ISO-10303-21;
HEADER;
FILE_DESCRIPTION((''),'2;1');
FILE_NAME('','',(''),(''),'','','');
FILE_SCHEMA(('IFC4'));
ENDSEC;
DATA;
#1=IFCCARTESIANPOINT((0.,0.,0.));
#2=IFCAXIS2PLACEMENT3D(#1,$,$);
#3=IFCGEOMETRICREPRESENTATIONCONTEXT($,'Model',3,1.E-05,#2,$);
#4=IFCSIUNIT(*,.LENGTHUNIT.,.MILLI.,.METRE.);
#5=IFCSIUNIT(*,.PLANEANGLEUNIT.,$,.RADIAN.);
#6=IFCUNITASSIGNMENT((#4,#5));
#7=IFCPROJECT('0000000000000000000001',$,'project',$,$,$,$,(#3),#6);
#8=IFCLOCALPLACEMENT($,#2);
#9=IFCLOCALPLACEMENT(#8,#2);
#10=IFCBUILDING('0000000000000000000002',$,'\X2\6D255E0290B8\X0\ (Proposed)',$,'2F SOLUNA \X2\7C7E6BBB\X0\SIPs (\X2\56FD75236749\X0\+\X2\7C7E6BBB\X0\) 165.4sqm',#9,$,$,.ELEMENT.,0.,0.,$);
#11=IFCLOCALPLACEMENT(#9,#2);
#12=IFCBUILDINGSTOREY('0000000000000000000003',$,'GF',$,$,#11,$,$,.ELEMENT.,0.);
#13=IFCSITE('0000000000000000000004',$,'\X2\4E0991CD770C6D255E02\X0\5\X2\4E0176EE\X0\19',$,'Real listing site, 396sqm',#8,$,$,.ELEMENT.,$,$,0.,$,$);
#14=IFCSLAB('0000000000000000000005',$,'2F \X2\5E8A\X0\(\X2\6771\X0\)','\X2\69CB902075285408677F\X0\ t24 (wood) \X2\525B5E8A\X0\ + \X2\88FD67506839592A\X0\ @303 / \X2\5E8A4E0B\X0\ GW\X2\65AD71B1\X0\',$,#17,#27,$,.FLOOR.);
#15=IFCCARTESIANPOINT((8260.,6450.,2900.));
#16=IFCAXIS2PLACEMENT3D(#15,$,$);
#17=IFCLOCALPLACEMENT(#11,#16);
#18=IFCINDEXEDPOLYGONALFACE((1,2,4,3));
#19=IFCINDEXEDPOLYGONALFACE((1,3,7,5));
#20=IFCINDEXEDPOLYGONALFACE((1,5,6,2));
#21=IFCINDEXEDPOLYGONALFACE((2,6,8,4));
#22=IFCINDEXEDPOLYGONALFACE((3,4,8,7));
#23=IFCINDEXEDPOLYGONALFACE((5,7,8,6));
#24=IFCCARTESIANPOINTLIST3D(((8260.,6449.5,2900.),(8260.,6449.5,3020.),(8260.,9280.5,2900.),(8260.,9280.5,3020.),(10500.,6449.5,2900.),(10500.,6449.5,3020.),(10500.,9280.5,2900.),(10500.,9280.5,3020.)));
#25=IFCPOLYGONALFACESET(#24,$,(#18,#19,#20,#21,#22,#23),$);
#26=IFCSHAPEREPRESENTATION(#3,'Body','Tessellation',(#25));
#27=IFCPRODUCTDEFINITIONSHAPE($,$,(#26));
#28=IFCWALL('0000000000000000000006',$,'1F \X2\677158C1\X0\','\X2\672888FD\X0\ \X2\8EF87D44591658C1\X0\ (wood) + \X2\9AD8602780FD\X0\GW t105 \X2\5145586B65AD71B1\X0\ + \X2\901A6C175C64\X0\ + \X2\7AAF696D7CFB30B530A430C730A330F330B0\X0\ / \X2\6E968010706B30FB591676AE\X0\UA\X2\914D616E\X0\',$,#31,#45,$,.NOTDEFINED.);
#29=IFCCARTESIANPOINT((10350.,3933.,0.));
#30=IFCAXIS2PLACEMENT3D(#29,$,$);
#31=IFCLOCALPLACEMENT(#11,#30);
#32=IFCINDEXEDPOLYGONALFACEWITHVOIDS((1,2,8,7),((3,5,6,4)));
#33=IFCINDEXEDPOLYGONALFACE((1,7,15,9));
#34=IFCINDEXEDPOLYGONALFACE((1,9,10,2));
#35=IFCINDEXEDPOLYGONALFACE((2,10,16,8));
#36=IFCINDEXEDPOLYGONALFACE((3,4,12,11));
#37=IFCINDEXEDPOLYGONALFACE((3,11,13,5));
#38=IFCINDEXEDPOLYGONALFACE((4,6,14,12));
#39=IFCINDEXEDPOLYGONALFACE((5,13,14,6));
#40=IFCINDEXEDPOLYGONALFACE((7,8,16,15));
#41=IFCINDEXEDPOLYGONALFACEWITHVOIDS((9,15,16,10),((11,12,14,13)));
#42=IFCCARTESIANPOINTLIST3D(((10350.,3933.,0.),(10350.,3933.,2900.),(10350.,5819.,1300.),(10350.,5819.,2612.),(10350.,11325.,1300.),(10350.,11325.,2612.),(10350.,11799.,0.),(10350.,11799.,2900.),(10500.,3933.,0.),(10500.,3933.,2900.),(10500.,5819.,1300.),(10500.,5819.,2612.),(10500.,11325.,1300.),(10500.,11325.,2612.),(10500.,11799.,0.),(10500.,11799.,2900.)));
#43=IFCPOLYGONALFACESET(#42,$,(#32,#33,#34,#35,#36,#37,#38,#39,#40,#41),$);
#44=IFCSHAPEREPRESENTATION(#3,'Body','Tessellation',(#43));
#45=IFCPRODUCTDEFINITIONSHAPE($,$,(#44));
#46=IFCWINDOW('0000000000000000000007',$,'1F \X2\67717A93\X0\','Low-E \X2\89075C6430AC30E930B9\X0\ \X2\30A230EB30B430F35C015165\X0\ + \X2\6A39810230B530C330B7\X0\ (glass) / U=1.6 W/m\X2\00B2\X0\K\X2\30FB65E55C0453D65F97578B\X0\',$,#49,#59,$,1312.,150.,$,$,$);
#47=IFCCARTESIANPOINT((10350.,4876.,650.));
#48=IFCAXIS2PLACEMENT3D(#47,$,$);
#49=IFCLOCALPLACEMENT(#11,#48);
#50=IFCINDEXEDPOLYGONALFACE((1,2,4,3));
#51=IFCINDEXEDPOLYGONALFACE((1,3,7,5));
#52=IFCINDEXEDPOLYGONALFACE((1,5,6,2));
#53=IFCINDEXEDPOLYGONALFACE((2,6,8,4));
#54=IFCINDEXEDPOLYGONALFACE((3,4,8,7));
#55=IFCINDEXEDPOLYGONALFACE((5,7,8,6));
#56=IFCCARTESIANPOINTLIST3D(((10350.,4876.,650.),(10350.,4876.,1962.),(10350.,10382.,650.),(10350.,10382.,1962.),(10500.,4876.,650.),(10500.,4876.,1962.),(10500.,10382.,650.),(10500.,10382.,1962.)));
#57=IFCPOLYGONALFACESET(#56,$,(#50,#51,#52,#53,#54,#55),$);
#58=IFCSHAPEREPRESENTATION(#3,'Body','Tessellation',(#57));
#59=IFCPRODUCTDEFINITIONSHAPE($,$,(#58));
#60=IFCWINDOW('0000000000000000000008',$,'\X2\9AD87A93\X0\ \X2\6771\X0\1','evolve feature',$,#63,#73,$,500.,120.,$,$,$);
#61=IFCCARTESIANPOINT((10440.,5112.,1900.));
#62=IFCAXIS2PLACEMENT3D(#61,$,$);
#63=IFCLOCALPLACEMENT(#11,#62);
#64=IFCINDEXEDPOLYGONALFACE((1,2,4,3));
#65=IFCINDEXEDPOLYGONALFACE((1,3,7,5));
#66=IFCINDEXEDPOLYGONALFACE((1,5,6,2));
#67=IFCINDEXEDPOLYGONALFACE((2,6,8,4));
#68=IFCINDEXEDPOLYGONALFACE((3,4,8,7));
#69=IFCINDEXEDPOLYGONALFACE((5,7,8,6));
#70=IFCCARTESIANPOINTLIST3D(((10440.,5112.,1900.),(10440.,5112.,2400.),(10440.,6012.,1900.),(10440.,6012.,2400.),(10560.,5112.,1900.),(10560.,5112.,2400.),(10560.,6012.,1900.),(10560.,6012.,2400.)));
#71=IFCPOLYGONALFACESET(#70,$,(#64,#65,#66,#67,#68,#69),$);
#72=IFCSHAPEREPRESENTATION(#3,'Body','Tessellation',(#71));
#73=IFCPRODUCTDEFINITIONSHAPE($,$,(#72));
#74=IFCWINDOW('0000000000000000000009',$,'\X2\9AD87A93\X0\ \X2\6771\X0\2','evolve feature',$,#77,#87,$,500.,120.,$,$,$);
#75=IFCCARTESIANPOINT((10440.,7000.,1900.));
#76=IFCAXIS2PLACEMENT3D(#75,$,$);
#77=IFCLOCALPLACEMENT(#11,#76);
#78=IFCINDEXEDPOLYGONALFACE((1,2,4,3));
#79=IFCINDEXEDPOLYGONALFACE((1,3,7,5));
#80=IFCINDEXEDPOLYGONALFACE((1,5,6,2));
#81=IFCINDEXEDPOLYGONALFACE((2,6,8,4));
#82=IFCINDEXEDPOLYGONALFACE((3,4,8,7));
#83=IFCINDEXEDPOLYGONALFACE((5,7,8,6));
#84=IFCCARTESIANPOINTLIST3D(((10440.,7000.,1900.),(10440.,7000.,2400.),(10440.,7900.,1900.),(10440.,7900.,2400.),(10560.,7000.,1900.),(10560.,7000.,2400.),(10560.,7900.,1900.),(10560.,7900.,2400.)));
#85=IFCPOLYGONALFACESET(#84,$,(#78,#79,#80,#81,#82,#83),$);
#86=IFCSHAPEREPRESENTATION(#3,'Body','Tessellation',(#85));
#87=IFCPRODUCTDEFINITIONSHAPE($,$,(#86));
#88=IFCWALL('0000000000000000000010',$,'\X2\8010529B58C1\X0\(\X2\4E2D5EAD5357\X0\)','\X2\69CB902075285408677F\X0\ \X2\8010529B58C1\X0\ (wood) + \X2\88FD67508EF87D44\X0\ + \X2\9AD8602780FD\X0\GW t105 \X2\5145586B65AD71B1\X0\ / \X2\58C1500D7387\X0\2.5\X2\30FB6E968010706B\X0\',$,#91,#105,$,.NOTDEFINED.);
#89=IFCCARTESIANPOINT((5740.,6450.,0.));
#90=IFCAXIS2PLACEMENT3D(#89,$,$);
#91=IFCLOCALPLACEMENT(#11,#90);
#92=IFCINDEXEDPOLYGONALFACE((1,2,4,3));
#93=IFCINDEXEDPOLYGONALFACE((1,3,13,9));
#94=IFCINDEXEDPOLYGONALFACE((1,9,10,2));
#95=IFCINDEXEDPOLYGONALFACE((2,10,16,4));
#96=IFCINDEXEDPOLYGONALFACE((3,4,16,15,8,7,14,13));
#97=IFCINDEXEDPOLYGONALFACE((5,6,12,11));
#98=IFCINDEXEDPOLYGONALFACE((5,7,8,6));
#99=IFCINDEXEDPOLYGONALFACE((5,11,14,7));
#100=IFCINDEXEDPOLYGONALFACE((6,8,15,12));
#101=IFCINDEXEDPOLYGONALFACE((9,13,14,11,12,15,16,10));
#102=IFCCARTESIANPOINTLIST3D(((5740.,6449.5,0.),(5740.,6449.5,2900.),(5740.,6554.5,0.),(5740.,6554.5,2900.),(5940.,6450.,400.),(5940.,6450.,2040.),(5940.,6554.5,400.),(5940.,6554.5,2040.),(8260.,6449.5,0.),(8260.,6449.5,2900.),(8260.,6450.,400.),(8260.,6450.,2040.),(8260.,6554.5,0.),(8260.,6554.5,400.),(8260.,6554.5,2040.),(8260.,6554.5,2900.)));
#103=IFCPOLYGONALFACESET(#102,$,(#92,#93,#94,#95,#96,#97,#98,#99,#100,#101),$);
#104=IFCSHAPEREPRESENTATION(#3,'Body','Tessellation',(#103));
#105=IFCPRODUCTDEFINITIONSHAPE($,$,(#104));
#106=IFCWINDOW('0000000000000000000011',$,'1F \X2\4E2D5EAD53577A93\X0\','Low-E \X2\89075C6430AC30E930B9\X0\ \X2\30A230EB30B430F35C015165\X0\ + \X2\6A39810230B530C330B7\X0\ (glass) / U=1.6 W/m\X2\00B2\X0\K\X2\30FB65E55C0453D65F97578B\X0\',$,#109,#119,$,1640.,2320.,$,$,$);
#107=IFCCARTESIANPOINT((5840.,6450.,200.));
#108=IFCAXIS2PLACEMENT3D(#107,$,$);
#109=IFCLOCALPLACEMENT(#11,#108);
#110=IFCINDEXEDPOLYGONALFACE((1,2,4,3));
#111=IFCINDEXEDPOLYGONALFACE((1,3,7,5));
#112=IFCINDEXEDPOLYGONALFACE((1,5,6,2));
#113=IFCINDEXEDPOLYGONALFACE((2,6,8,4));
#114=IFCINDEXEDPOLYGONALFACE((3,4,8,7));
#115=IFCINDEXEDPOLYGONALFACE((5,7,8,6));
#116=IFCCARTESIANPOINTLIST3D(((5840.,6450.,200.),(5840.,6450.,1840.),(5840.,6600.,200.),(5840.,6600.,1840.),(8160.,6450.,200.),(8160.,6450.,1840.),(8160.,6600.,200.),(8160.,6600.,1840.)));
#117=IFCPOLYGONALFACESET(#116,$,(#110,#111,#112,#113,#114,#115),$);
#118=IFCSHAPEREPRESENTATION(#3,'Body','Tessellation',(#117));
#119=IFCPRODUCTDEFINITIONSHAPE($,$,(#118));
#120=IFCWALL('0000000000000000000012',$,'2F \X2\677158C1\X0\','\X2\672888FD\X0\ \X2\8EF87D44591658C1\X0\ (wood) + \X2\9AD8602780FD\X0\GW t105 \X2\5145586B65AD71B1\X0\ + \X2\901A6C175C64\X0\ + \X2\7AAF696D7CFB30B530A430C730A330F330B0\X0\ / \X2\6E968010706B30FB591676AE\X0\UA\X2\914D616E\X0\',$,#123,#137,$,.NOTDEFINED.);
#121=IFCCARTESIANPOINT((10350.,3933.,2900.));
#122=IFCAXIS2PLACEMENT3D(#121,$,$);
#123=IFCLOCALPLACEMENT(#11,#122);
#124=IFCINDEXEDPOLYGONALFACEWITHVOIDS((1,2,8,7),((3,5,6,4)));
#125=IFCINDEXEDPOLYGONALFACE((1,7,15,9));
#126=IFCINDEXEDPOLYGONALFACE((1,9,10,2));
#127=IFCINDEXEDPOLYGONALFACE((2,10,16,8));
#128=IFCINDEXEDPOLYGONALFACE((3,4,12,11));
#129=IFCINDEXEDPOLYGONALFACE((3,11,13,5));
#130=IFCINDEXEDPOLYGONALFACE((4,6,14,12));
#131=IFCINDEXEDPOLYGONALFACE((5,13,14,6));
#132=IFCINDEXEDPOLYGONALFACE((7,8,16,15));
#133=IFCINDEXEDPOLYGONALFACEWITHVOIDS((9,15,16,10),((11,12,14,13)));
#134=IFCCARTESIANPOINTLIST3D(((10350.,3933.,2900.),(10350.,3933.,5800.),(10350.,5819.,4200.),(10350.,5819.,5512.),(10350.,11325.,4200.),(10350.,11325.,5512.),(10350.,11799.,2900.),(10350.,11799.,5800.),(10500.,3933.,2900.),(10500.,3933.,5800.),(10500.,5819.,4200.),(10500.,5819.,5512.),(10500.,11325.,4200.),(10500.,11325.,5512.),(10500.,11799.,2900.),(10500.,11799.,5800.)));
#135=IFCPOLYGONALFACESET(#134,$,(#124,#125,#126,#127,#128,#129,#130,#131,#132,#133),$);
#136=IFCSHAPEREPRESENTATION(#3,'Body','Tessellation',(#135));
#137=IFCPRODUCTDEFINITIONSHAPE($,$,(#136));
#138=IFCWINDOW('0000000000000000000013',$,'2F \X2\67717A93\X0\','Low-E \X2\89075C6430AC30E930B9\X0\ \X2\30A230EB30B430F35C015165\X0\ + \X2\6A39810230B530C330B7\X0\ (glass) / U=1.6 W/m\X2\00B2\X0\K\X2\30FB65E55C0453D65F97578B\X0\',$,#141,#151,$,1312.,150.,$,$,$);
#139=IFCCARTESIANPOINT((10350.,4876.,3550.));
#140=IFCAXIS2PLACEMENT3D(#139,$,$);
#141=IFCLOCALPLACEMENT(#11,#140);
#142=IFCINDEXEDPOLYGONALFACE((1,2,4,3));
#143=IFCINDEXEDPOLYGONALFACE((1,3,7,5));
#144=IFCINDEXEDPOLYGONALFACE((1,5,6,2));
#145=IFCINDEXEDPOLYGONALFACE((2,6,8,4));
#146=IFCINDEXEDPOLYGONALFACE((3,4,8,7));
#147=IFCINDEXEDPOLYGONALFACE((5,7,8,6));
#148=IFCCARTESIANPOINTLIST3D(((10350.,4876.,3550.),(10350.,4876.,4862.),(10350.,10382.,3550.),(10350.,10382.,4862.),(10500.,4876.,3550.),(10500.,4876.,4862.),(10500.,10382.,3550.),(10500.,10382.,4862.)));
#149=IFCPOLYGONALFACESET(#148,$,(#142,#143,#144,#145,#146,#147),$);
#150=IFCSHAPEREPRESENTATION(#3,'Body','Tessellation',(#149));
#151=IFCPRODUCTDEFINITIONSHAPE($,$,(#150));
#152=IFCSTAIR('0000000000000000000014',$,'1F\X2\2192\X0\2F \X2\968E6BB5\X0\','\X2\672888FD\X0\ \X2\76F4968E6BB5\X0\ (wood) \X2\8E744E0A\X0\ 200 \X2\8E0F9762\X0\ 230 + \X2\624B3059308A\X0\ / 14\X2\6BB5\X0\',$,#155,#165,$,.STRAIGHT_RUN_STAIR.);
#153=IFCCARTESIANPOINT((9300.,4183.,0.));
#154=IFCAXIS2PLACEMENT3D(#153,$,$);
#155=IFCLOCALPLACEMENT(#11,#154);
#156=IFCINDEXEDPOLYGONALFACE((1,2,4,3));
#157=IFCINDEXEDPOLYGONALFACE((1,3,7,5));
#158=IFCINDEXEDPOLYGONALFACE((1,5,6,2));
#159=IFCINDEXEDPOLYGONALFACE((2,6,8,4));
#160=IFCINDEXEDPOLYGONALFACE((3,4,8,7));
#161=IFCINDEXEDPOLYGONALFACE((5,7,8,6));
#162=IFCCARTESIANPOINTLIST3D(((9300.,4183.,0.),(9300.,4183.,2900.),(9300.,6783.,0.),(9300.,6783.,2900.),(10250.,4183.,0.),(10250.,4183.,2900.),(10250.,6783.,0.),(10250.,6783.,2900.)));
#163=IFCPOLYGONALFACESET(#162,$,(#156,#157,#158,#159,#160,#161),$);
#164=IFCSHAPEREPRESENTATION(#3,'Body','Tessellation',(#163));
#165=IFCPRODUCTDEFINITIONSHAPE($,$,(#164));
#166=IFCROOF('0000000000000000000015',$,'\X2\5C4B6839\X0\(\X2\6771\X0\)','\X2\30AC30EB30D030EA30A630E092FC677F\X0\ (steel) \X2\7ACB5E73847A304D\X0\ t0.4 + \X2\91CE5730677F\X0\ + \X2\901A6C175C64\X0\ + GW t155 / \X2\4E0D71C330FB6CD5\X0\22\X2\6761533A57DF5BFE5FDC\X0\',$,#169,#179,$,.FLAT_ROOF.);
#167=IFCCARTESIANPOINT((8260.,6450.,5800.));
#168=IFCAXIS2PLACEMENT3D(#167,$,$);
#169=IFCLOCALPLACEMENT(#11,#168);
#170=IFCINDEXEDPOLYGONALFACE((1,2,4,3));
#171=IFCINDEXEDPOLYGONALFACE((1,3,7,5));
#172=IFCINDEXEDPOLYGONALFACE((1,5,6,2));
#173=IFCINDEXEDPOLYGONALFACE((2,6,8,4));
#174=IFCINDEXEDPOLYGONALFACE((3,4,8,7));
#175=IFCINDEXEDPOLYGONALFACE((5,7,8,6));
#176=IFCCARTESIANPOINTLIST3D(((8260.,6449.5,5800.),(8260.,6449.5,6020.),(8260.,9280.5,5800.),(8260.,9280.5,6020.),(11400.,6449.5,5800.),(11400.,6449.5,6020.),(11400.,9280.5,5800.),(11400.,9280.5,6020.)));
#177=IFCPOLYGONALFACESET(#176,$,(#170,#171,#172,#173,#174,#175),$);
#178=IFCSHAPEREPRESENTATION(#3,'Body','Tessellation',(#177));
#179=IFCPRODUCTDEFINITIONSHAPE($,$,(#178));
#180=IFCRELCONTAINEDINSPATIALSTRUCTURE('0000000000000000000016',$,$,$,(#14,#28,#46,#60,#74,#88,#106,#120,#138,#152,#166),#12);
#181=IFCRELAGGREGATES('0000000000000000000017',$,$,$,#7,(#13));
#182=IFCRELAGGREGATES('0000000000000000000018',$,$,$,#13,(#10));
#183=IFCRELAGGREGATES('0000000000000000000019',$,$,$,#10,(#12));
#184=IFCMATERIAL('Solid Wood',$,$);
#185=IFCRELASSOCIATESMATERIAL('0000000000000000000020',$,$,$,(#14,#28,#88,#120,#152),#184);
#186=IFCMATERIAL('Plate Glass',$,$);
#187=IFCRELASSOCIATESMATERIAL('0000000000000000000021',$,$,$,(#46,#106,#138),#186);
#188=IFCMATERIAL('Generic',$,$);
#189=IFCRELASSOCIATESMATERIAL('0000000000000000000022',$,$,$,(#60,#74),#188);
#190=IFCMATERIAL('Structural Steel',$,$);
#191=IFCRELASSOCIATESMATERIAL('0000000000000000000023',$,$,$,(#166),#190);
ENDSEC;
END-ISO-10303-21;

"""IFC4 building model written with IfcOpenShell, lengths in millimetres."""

from ifc_helpers import new_model, si_unit, frame, frame_2d, origin, place, context, project, spatial, rectangle, extrude, material, element, fill, save


model = new_model("IFC4")

# Units and contexts
model_context = context("Model", 3, precision=1e-05, world=origin())
ifc_project = project(units=[si_unit("LENGTHUNIT", "METRE", prefix="MILLI"), si_unit("PLANEANGLEUNIT", "RADIAN")], contexts=[model_context])

# Site, building, storey
site_placement = place(None, origin())
site = spatial("IfcSite", under=ifc_project, at=site_placement, Name="三重県津市5丁目19", ObjectType="Real listing site, 396sqm", CompositionType="ELEMENT", RefElevation=0.0)
building_placement = place(site_placement, origin())
building = spatial("IfcBuilding", under=site, at=building_placement, Name="津市邸 (Proposed)", ObjectType="2F SOLUNA 籾殻SIPs (国産杉+籾殻) 165.4sqm", CompositionType="ELEMENT", ElevationOfRefHeight=0.0, ElevationOfTerrain=0.0)
storey_placement = place(building_placement, origin())
storey = spatial("IfcBuildingStorey", under=building, at=storey_placement, Name="GF", CompositionType="ELEMENT", Elevation=0.0)

# Slab
ifc_material_1 = material(Name="Solid Wood")
slab_1_placement = place(storey_placement, frame((8260.0, 6450.0, 2900.0)))
element("IfcSlab", 1, at=slab_1_placement, inside=storey, material=ifc_material_1, Name="2F 床(東)", Description="構造用合板 t24 (wood) 剛床 + 製材根太 @303 / 床下 GW断熱", PredefinedType="FLOOR", context=model_context, shape_type="SweptSolid", body=[
    extrude(rectangle(XDim=2240.0, YDim=2831.0, at=frame_2d((1120.0, 1415.0))), frame((8260.0, 6450.0, 2900.0)), (0.0, 0.0, 1.0), 120.0),
])

# Wall, openings, windows
wall_1_placement = place(storey_placement, frame((10350.0, 3933.0, 0.0)))
wall_1 = element("IfcWall", 2, at=wall_1_placement, inside=storey, material=ifc_material_1, Name="1F 東壁", Description="木製 軸組外壁 (wood) + 高性能GW t105 充填断熱 + 通気層 + 窯業系サイディング / 準耐火・外皮UA配慮", PredefinedType="NOTDEFINED", context=model_context, shape_type="SweptSolid", body=[
    extrude(rectangle(XDim=150.0, YDim=7866.0, at=frame_2d((75.0, 3933.0))), frame((10350.0, 3933.0, 0.0)), (0.0, 0.0, 1.0), 2900.0),
])
opening_1_placement = place(storey_placement, frame((10350.0, 4876.0, 650.0)))
opening_1 = element("IfcOpeningElement", 3, at=opening_1_placement, cuts=wall_1, PredefinedType="NOTDEFINED", context=model_context, shape_type="SweptSolid", body=[
    extrude(rectangle(XDim=150.0, YDim=5506.0, at=frame_2d((75.0, 2753.0))), frame((10350.0, 4876.0, 650.0)), (0.0, 0.0, 1.0), 1312.0),
])
opening_2_placement = place(storey_placement, frame((10440.0, 5112.0, 1900.0)))
opening_2 = element("IfcOpeningElement", 4, at=opening_2_placement, cuts=wall_1, PredefinedType="NOTDEFINED", context=model_context, shape_type="SweptSolid", body=[
    extrude(rectangle(XDim=120.0, YDim=900.0, at=frame_2d((60.0, 450.0))), frame((10440.0, 5112.0, 1900.0)), (0.0, 0.0, 1.0), 500.0),
])
opening_3_placement = place(storey_placement, frame((10440.0, 7000.0, 1900.0)))
opening_3 = element("IfcOpeningElement", 5, at=opening_3_placement, cuts=wall_1, PredefinedType="NOTDEFINED", context=model_context, shape_type="SweptSolid", body=[
    extrude(rectangle(XDim=120.0, YDim=900.0, at=frame_2d((60.0, 450.0))), frame((10440.0, 7000.0, 1900.0)), (0.0, 0.0, 1.0), 500.0),
])
ifc_material_2 = material(Name="Plate Glass")
window_1_placement = place(storey_placement, frame((10350.0, 4876.0, 650.0)))
window_1 = element("IfcWindow", 6, at=window_1_placement, inside=storey, material=ifc_material_2, Name="1F 東窓", Description="Low-E 複層ガラス アルゴン封入 + 樹脂サッシ (glass) / U=1.6 W/m²K・日射取得型", OverallHeight=1312.0, OverallWidth=150.0, context=model_context, shape_type="SweptSolid", body=[
    extrude(rectangle(XDim=150.0, YDim=5506.0, at=frame_2d((75.0, 2753.0))), frame((10350.0, 4876.0, 650.0)), (0.0, 0.0, 1.0), 1312.0),
])
fill(opening_1, window_1)
ifc_material_3 = material(Name="Generic")
window_2_placement = place(storey_placement, frame((10440.0, 5112.0, 1900.0)))
window_2 = element("IfcWindow", 7, at=window_2_placement, inside=storey, material=ifc_material_3, Name="高窓 東1", Description="evolve feature", OverallHeight=500.0, OverallWidth=120.0, context=model_context, shape_type="SweptSolid", body=[
    extrude(rectangle(XDim=120.0, YDim=900.0, at=frame_2d((60.0, 450.0))), frame((10440.0, 5112.0, 1900.0)), (0.0, 0.0, 1.0), 500.0),
])
fill(opening_2, window_2)
window_3_placement = place(storey_placement, frame((10440.0, 7000.0, 1900.0)))
window_3 = element("IfcWindow", 8, at=window_3_placement, inside=storey, material=ifc_material_3, Name="高窓 東2", Description="evolve feature", OverallHeight=500.0, OverallWidth=120.0, context=model_context, shape_type="SweptSolid", body=[
    extrude(rectangle(XDim=120.0, YDim=900.0, at=frame_2d((60.0, 450.0))), frame((10440.0, 7000.0, 1900.0)), (0.0, 0.0, 1.0), 500.0),
])
fill(opening_3, window_3)

# Wall, opening, window
wall_2_placement = place(storey_placement, frame((5740.0, 6450.0, 0.0)))
wall_2 = element("IfcWall", 9, at=wall_2_placement, inside=storey, material=ifc_material_1, Name="耐力壁(中庭南)", Description="構造用合板 耐力壁 (wood) + 製材軸組 + 高性能GW t105 充填断熱 / 壁倍率2.5・準耐火", PredefinedType="NOTDEFINED", context=model_context, shape_type="SweptSolid", body=[
    extrude(rectangle(XDim=2520.0, YDim=105.0, at=frame_2d((1260.0, 52.0))), frame((5740.0, 6450.0, 0.0)), (0.0, 0.0, 1.0), 2900.0),
])
opening_4_placement = place(storey_placement, frame((5840.0, 6450.0, 200.0)))
opening_4 = element("IfcOpeningElement", 10, at=opening_4_placement, cuts=wall_2, PredefinedType="NOTDEFINED", context=model_context, shape_type="SweptSolid", body=[
    extrude(rectangle(XDim=2320.0, YDim=150.0, at=frame_2d((1160.0, 75.0))), frame((5840.0, 6450.0, 200.0)), (0.0, 0.0, 1.0), 1640.0),
])
window_4_placement = place(storey_placement, frame((5840.0, 6450.0, 200.0)))
window_4 = element("IfcWindow", 11, at=window_4_placement, inside=storey, material=ifc_material_2, Name="1F 中庭南窓", Description="Low-E 複層ガラス アルゴン封入 + 樹脂サッシ (glass) / U=1.6 W/m²K・日射取得型", OverallHeight=1640.0, OverallWidth=2320.0, context=model_context, shape_type="SweptSolid", body=[
    extrude(rectangle(XDim=2320.0, YDim=150.0, at=frame_2d((1160.0, 75.0))), frame((5840.0, 6450.0, 200.0)), (0.0, 0.0, 1.0), 1640.0),
])
fill(opening_4, window_4)

# Wall, opening, window
wall_3_placement = place(storey_placement, frame((10350.0, 3933.0, 2900.0)))
wall_3 = element("IfcWall", 12, at=wall_3_placement, inside=storey, material=ifc_material_1, Name="2F 東壁", Description="木製 軸組外壁 (wood) + 高性能GW t105 充填断熱 + 通気層 + 窯業系サイディング / 準耐火・外皮UA配慮", PredefinedType="NOTDEFINED", context=model_context, shape_type="SweptSolid", body=[
    extrude(rectangle(XDim=150.0, YDim=7866.0, at=frame_2d((75.0, 3933.0))), frame((10350.0, 3933.0, 2900.0)), (0.0, 0.0, 1.0), 2900.0),
])
opening_5_placement = place(storey_placement, frame((10350.0, 4876.0, 3550.0)))
opening_5 = element("IfcOpeningElement", 13, at=opening_5_placement, cuts=wall_3, PredefinedType="NOTDEFINED", context=model_context, shape_type="SweptSolid", body=[
    extrude(rectangle(XDim=150.0, YDim=5506.0, at=frame_2d((75.0, 2753.0))), frame((10350.0, 4876.0, 3550.0)), (0.0, 0.0, 1.0), 1312.0),
])
window_5_placement = place(storey_placement, frame((10350.0, 4876.0, 3550.0)))
window_5 = element("IfcWindow", 14, at=window_5_placement, inside=storey, material=ifc_material_2, Name="2F 東窓", Description="Low-E 複層ガラス アルゴン封入 + 樹脂サッシ (glass) / U=1.6 W/m²K・日射取得型", OverallHeight=1312.0, OverallWidth=150.0, context=model_context, shape_type="SweptSolid", body=[
    extrude(rectangle(XDim=150.0, YDim=5506.0, at=frame_2d((75.0, 2753.0))), frame((10350.0, 4876.0, 3550.0)), (0.0, 0.0, 1.0), 1312.0),
])
fill(opening_5, window_5)

# Stair
stair_placement = place(storey_placement, frame((9300.0, 4183.0, 0.0)))
element("IfcStair", 15, at=stair_placement, inside=storey, material=ifc_material_1, Name="1F→2F 階段", Description="木製 直階段 (wood) 蹴上 200 踏面 230 + 手すり / 14段", PredefinedType="STRAIGHT_RUN_STAIR", context=model_context, shape_type="SweptSolid", body=[
    extrude(rectangle(XDim=950.0, YDim=2600.0, at=frame_2d((475.0, 1300.0))), frame((9300.0, 4183.0, 0.0)), (0.0, 0.0, 1.0), 2900.0),
])

# Roof
ifc_material_4 = material(Name="Structural Steel")
roof_placement = place(storey_placement, frame((8260.0, 6450.0, 5800.0)))
element("IfcRoof", 16, at=roof_placement, inside=storey, material=ifc_material_4, Name="屋根(東)", Description="ガルバリウム鋼板 (steel) 立平葺き t0.4 + 野地板 + 通気層 + GW t155 / 不燃・法22条区域対応", PredefinedType="FLAT_ROOF", context=model_context, shape_type="SweptSolid", body=[
    extrude(rectangle(XDim=3140.0, YDim=2831.0, at=frame_2d((1570.0, 1415.0))), frame((8260.0, 6450.0, 5800.0)), (0.0, 0.0, 1.0), 220.0),
])

save(model, "model.ifc")
